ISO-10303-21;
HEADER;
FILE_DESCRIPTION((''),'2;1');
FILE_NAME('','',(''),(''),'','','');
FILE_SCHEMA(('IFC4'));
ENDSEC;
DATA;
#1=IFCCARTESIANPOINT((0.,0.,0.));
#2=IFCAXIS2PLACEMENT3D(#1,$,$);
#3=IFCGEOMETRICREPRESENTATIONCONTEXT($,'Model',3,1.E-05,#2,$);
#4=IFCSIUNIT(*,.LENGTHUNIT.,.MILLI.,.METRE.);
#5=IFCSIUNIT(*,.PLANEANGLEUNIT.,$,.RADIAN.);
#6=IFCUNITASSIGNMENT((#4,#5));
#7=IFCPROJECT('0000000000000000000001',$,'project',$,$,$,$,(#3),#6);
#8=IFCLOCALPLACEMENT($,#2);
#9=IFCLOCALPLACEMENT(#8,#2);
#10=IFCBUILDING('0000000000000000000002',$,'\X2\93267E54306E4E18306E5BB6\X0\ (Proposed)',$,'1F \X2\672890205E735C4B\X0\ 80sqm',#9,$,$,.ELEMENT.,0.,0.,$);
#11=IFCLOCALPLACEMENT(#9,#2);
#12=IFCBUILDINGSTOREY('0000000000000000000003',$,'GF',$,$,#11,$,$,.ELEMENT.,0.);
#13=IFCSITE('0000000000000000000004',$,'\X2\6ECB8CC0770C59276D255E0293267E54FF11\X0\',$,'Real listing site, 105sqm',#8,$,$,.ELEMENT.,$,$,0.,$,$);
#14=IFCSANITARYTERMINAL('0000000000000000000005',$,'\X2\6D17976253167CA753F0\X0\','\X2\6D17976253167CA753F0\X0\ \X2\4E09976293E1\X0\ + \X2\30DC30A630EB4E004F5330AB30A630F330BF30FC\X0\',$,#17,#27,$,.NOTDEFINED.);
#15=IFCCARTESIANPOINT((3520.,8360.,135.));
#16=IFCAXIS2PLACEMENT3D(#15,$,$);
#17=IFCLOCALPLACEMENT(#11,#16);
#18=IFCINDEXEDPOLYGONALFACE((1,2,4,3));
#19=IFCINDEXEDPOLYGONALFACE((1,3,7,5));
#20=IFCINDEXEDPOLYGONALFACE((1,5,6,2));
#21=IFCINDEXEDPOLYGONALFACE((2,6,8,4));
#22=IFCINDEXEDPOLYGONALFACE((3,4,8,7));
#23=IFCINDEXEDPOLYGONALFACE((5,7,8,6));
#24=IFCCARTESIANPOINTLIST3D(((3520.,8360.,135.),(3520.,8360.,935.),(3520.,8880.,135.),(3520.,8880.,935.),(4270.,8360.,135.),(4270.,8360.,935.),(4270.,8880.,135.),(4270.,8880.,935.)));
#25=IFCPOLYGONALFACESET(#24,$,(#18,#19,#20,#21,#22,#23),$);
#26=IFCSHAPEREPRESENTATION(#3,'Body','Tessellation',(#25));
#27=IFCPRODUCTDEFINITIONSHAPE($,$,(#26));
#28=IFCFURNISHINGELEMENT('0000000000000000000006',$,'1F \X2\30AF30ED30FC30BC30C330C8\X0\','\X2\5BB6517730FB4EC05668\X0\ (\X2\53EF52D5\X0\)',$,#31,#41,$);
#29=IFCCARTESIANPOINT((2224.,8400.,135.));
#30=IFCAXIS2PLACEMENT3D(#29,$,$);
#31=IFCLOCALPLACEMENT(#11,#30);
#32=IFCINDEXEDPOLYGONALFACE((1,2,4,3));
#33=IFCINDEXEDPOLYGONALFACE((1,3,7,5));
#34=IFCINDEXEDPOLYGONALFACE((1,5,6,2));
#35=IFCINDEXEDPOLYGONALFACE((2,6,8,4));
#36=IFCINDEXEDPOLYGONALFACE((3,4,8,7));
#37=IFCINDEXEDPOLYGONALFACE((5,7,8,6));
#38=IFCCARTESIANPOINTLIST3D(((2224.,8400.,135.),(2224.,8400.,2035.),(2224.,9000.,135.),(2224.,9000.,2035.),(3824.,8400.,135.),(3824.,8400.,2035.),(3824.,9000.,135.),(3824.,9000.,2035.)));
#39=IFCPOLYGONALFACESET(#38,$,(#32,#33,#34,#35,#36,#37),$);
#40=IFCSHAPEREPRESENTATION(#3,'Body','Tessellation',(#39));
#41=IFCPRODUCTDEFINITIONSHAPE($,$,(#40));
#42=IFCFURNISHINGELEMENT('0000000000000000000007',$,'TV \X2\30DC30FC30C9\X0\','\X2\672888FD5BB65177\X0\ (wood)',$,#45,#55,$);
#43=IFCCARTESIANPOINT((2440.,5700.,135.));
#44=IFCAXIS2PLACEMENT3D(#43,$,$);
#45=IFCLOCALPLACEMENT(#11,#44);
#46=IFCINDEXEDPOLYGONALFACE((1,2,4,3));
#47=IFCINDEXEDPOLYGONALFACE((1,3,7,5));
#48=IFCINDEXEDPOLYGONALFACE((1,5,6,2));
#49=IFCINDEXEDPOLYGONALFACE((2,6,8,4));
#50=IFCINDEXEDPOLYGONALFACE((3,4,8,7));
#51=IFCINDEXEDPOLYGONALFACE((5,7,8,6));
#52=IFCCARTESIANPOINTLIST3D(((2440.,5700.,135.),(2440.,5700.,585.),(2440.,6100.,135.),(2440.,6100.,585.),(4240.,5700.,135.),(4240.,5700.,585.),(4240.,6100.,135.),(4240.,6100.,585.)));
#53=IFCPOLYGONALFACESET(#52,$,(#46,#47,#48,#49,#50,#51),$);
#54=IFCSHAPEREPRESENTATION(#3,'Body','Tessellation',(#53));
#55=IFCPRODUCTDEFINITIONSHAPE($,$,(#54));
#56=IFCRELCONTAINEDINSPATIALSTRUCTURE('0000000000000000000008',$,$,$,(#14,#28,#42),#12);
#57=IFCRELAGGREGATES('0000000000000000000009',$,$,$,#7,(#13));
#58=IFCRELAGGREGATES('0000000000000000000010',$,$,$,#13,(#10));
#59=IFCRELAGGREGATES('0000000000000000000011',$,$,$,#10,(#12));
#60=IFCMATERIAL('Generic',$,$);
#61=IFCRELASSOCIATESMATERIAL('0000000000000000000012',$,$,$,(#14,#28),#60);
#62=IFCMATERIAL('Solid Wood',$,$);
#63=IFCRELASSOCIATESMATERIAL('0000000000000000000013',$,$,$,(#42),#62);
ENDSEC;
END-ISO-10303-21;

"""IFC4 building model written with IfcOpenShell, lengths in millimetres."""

from ifc_helpers import new_model, si_unit, frame, frame_2d, origin, place, context, project, spatial, rectangle, extrude, material, element, save


model = new_model("IFC4")

# Units and contexts
model_context = context("Model", 3, precision=1e-05, world=origin())
ifc_project = project(units=[si_unit("LENGTHUNIT", "METRE", prefix="MILLI"), si_unit("PLANEANGLEUNIT", "RADIAN")], contexts=[model_context])

# Site, building, storey
site_placement = place(None, origin())
site = spatial("IfcSite", under=ifc_project, at=site_placement, Name="滋賀県大津市錦織１", ObjectType="Real listing site, 105sqm", CompositionType="ELEMENT", RefElevation=0.0)
building_placement = place(site_placement, origin())
building = spatial("IfcBuilding", under=site, at=building_placement, Name="錦織の丘の家 (Proposed)", ObjectType="1F 木造平屋 80sqm", CompositionType="ELEMENT", ElevationOfRefHeight=0.0, ElevationOfTerrain=0.0)
storey_placement = place(building_placement, origin())
storey = spatial("IfcBuildingStorey", under=building, at=storey_placement, Name="GF", CompositionType="ELEMENT", Elevation=0.0)

# Shared definitions
ifc_material_1 = material(Name="Solid Wood")

# Shared definitions
ifc_material_2 = material(Name="Generic")

# Sanitary terminal
sanitary_terminal_1_placement = place(storey_placement, frame((3520.0, 8360.0, 135.0)))
element("IfcSanitaryTerminal", 1, at=sanitary_terminal_1_placement, inside=storey, material=ifc_material_2, Name="洗面化粧台", Description="洗面化粧台 三面鏡 + ボウル一体カウンター", PredefinedType="NOTDEFINED", context=model_context, shape_type="SweptSolid", body=[
    extrude(rectangle(XDim=750.0, YDim=520.0, at=frame_2d((375.0, 260.0))), frame((3520.0, 8360.0, 135.0)), (0.0, 0.0, 1.0), 800.0),
])

# Furnishing elements
furnishing_1_placement = place(storey_placement, frame((2224.0, 8400.0, 135.0)))
element("IfcFurnishingElement", 2, at=furnishing_1_placement, inside=storey, material=ifc_material_2, Name="1F クローゼット", Description="家具・什器 (可動)", context=model_context, shape_type="SweptSolid", body=[
    extrude(rectangle(XDim=1600.0, YDim=600.0, at=frame_2d((800.0, 300.0))), frame((2224.0, 8400.0, 135.0)), (0.0, 0.0, 1.0), 1900.0),
])
furnishing_2_placement = place(storey_placement, frame((2440.0, 5700.0, 135.0)))
element("IfcFurnishingElement", 3, at=furnishing_2_placement, inside=storey, material=ifc_material_1, Name="TV ボード", Description="木製家具 (wood)", context=model_context, shape_type="SweptSolid", body=[
    extrude(rectangle(XDim=1800.0, YDim=400.0, at=frame_2d((900.0, 200.0))), frame((2440.0, 5700.0, 135.0)), (0.0, 0.0, 1.0), 450.0),
])

save(model, "model.ifc")
